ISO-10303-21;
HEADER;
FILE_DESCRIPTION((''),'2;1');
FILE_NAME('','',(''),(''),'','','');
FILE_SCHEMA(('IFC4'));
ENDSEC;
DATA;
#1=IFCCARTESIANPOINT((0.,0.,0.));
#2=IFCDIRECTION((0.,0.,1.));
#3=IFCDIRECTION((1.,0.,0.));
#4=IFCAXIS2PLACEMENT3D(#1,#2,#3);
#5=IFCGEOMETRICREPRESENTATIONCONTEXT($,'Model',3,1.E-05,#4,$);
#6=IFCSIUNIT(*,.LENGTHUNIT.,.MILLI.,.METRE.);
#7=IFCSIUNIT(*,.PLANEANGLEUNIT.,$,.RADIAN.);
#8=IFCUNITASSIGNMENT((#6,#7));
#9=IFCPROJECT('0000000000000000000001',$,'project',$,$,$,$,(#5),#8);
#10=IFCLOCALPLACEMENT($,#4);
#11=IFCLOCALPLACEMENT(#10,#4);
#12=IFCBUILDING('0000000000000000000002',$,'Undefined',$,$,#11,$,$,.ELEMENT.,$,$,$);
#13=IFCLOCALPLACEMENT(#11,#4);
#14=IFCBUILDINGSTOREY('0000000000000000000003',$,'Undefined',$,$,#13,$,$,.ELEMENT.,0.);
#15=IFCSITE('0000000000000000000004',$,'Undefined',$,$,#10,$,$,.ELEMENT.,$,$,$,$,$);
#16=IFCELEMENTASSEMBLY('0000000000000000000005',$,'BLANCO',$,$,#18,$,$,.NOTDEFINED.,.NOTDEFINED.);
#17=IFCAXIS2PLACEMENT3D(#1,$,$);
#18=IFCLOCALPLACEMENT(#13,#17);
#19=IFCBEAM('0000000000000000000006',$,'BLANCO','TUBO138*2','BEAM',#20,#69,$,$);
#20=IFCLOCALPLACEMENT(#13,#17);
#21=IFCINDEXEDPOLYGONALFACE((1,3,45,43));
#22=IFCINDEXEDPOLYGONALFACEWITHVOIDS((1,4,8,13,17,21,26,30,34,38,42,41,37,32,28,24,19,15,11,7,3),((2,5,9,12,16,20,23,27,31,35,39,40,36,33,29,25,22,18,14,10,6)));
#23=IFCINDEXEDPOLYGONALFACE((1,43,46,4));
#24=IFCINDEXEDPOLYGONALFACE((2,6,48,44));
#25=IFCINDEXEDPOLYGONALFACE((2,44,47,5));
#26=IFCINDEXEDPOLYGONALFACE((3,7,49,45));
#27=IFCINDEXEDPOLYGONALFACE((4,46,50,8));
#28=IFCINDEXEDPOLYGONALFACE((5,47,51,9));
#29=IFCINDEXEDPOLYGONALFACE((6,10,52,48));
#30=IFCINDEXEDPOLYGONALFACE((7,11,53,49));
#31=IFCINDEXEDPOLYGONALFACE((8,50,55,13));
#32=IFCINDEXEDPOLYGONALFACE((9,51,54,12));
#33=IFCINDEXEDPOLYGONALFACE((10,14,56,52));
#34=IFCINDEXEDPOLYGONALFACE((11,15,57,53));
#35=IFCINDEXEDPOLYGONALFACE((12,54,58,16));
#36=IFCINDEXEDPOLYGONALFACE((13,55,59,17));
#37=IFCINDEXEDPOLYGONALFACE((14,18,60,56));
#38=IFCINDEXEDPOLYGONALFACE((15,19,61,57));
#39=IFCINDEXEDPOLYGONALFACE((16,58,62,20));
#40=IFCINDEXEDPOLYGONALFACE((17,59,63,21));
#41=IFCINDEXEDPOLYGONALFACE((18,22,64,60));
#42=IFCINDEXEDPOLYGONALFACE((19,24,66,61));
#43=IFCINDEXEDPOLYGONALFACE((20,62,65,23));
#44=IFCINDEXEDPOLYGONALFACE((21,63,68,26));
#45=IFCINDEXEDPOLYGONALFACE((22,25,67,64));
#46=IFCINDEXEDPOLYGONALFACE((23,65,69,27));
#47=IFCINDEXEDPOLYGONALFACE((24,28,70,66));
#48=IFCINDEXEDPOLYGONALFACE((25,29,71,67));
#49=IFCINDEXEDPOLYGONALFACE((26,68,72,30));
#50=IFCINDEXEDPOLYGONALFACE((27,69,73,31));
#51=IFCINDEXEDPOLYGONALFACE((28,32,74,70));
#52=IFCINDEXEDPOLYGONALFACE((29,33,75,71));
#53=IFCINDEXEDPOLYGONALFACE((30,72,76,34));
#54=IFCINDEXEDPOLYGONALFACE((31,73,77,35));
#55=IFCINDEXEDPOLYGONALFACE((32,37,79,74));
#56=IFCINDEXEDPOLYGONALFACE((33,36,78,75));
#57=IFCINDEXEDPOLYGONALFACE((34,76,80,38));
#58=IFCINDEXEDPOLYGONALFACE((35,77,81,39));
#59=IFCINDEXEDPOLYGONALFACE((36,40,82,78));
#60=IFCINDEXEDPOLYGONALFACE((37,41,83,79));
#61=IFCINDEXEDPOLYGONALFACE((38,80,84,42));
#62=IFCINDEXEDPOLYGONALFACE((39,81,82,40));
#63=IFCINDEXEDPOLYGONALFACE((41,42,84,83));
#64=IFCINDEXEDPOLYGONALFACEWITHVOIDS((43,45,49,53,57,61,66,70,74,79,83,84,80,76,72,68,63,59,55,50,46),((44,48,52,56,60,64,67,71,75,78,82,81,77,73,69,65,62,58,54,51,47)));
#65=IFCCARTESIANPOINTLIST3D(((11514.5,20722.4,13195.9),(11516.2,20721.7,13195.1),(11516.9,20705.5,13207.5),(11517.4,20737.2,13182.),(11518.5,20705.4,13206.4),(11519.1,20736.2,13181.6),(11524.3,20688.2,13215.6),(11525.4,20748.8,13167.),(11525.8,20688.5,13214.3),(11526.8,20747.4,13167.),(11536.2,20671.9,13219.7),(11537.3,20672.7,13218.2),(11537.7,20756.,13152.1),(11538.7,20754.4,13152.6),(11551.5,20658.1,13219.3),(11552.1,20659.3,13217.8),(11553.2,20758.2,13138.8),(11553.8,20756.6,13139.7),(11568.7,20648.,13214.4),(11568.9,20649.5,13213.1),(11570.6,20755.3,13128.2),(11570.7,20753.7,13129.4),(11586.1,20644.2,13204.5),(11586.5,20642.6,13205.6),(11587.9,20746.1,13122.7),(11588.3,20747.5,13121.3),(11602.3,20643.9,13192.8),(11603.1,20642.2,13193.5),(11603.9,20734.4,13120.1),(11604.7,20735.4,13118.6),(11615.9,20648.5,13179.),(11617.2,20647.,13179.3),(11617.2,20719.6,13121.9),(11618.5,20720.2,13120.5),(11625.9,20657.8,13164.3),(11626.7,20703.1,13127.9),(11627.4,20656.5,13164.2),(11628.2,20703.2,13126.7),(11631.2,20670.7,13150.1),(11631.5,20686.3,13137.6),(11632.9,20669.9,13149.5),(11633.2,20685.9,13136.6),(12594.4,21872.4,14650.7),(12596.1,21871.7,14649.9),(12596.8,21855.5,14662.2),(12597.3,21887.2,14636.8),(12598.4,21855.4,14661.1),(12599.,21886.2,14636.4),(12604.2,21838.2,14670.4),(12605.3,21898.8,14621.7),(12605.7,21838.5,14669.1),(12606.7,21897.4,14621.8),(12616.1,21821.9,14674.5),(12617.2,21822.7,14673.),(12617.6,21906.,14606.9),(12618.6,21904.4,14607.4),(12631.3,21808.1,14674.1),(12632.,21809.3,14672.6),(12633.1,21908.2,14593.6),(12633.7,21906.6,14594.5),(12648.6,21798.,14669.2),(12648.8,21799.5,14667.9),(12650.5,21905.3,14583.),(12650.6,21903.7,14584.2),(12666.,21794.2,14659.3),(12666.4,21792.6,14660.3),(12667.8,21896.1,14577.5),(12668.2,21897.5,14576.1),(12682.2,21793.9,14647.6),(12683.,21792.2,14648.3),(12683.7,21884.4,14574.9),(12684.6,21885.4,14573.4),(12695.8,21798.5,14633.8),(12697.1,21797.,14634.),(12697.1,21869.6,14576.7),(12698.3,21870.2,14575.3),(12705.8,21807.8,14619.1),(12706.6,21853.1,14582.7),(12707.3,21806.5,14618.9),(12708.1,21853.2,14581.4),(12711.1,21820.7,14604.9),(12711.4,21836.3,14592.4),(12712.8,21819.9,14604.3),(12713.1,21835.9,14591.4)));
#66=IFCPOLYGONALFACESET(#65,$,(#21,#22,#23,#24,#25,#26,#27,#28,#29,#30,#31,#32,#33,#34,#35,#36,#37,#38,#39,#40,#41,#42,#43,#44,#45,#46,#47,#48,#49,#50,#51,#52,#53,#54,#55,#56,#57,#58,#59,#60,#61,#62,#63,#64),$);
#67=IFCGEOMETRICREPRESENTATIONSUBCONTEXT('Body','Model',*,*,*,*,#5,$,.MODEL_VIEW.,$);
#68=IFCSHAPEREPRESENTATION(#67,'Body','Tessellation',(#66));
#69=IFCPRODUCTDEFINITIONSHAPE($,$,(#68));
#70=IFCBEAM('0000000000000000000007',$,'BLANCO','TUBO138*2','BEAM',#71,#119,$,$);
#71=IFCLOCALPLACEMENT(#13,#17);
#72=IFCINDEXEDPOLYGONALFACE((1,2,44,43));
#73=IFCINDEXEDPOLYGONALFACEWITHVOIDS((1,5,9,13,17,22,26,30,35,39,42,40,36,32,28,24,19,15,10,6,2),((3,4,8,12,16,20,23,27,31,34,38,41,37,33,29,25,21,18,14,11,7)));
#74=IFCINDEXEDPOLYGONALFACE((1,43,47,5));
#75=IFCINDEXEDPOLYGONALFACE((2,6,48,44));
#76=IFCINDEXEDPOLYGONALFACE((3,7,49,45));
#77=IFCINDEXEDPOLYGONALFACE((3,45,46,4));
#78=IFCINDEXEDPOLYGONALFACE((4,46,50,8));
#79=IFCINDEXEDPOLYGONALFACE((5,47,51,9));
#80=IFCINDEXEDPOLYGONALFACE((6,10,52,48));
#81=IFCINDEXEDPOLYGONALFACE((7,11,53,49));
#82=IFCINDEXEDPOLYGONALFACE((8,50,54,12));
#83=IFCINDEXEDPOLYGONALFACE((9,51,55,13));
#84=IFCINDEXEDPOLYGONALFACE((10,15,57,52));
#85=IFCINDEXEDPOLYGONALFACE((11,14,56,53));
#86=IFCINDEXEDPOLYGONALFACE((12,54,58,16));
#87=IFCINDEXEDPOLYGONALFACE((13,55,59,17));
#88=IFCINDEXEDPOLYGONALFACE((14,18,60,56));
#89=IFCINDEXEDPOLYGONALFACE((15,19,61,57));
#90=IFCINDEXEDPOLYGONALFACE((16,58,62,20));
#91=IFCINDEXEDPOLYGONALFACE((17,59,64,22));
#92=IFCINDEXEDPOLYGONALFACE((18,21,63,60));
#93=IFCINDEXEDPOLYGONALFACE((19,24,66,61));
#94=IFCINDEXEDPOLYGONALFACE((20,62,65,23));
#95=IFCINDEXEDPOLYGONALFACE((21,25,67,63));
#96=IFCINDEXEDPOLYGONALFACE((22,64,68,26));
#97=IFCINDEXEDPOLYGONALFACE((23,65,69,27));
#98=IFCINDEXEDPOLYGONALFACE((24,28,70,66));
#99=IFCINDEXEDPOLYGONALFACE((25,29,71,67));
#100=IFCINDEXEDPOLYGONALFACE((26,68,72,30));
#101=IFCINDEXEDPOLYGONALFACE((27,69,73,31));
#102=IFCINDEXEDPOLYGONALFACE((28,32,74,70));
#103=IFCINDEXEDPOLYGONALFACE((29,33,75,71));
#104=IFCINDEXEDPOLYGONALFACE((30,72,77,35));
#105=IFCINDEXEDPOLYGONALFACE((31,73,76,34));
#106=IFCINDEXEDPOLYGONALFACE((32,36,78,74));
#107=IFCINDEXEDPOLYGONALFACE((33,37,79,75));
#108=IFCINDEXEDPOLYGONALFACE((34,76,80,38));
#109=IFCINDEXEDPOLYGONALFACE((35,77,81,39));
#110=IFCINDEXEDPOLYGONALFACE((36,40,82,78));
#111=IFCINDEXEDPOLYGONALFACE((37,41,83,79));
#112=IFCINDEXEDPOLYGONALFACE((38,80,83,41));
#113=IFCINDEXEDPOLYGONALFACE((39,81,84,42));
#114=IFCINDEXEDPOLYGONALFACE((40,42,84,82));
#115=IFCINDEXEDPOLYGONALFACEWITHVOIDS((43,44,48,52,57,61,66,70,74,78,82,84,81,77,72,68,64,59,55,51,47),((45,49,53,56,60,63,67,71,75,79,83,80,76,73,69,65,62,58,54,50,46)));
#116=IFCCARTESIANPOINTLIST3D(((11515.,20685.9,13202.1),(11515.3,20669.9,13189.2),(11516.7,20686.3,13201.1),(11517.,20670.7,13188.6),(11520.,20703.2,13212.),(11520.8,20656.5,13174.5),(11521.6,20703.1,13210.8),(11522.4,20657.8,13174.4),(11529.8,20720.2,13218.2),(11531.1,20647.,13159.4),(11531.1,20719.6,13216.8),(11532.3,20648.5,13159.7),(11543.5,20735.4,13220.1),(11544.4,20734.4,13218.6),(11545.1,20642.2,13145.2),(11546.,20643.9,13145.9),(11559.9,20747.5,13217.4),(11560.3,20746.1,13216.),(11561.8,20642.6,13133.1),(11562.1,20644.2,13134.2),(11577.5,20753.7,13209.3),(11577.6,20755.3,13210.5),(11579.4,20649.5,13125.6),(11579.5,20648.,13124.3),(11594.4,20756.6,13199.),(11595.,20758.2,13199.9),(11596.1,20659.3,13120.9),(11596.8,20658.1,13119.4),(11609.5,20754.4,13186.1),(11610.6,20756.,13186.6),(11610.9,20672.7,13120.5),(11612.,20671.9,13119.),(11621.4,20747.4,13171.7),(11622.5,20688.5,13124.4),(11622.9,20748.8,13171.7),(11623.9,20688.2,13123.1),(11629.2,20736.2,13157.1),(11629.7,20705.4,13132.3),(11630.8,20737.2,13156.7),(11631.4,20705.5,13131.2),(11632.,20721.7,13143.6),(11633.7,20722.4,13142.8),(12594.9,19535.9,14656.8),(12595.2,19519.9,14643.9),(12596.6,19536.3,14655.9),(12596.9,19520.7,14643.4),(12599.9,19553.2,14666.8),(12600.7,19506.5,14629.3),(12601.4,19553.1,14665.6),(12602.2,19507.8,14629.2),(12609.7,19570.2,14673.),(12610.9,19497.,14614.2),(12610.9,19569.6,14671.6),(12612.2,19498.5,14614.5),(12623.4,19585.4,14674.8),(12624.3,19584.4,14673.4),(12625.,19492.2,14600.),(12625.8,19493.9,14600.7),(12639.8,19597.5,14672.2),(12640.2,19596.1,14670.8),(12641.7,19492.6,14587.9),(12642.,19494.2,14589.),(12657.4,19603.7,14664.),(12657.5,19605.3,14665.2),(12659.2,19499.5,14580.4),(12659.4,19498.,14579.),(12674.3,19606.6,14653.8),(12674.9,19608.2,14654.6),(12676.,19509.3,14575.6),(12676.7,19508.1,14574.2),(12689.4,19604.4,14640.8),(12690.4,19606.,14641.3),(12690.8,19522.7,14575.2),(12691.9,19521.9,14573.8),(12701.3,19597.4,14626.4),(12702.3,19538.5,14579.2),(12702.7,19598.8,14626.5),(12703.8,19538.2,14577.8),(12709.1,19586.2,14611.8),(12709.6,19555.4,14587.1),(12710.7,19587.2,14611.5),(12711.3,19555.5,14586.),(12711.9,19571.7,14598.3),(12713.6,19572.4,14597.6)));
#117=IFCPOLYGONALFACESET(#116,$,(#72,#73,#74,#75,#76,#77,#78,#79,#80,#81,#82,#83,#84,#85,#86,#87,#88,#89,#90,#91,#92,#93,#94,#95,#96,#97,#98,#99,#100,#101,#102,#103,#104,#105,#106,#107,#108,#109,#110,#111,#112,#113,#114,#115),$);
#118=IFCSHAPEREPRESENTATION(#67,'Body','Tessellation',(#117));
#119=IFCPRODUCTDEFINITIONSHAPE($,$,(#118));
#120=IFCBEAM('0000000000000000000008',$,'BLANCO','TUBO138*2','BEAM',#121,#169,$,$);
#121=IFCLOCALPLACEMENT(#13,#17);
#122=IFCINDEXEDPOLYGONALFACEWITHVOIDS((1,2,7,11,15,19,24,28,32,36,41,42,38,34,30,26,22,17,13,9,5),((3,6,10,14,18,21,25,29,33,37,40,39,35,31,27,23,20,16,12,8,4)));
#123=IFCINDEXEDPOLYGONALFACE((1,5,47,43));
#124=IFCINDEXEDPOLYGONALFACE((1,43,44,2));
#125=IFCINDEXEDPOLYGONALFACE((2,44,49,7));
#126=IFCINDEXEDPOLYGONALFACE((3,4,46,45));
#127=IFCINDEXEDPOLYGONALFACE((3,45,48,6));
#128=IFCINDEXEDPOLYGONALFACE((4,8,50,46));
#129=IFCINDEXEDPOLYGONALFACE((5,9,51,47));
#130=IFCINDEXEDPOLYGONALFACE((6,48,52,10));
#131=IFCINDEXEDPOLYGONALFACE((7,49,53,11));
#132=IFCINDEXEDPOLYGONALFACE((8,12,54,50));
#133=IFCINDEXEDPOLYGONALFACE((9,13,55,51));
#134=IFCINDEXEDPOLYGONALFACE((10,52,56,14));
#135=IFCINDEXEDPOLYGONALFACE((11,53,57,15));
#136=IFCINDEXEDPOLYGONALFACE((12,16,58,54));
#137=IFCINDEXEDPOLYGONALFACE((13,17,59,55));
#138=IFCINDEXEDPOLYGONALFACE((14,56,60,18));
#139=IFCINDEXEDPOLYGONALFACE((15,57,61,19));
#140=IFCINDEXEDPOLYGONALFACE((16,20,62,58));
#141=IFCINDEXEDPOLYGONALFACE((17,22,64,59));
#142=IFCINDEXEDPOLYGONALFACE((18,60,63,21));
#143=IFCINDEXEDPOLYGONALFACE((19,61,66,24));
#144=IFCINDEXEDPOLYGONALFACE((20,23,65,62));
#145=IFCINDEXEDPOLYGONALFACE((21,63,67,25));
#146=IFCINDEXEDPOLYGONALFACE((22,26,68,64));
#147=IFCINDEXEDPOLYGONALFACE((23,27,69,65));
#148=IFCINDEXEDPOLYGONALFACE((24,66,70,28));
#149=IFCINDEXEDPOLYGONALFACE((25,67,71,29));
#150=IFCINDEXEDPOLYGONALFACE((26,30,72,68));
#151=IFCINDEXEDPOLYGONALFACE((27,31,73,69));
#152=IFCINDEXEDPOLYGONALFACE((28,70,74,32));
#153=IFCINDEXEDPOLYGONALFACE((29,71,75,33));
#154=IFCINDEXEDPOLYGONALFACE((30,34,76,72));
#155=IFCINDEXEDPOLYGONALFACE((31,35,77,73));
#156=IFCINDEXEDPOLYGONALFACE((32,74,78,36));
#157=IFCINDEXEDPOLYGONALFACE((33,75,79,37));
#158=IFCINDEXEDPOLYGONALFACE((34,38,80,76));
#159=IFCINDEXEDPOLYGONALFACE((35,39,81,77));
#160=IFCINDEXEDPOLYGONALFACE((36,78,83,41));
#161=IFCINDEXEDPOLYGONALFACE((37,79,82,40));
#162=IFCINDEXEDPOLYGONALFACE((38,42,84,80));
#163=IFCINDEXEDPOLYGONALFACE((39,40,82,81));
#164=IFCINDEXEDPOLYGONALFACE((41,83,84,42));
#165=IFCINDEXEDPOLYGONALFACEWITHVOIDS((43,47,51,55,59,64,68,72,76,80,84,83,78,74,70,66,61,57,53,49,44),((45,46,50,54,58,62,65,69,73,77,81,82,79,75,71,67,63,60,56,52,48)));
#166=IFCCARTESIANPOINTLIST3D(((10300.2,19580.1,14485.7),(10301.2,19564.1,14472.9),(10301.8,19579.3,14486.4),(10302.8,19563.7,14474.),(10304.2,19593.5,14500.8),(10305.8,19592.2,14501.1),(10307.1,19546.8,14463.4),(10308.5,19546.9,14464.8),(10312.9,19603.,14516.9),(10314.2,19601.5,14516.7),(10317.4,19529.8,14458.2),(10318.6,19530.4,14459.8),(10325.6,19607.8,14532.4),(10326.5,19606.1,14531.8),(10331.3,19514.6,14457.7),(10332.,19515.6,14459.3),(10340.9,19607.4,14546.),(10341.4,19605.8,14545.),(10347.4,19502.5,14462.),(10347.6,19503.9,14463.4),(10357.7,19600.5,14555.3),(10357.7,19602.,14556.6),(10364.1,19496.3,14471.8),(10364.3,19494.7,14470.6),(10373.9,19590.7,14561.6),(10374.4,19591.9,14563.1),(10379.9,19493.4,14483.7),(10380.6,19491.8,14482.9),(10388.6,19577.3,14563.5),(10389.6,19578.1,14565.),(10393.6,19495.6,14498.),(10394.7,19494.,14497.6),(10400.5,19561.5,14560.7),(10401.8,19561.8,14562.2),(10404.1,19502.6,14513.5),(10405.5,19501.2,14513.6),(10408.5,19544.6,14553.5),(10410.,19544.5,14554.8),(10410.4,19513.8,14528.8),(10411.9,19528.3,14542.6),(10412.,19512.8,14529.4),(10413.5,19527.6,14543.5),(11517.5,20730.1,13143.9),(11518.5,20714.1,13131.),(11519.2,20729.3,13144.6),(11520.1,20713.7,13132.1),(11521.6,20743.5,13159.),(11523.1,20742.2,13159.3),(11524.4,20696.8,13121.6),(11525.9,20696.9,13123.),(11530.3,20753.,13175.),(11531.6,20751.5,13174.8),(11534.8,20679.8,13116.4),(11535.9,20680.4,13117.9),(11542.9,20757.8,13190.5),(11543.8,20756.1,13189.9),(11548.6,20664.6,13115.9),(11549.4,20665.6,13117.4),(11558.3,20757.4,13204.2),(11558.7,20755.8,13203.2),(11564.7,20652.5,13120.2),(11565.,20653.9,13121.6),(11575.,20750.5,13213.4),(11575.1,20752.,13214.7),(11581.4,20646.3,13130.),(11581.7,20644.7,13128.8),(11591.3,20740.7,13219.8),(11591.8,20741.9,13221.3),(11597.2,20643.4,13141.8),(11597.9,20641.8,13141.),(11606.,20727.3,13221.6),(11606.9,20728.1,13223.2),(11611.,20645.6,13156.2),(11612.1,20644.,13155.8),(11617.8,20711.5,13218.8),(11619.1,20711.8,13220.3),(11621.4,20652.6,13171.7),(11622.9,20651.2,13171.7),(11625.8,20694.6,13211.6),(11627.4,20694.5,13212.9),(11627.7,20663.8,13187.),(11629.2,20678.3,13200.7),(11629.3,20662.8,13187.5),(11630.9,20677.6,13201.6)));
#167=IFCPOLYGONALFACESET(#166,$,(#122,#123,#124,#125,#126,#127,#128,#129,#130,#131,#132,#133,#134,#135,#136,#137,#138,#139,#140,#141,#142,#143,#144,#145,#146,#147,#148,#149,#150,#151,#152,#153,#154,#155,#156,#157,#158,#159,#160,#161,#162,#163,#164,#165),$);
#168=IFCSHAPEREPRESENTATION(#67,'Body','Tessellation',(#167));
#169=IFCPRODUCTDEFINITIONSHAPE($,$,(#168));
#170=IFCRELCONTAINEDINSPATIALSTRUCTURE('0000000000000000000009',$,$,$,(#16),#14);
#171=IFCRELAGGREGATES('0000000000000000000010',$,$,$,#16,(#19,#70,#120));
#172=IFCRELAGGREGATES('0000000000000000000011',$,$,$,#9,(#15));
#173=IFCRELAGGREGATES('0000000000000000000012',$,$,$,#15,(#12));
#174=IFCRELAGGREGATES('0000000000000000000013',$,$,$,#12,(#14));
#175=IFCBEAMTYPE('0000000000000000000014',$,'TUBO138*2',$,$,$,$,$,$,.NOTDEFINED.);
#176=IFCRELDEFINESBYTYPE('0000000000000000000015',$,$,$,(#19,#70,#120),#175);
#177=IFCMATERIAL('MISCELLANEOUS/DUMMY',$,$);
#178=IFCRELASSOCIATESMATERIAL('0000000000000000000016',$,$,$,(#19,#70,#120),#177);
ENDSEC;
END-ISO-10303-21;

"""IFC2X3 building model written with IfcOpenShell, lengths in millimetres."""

from ifc_helpers import new_model, si_unit, frame, origin_with_axes, origin_2d_with_axis, place, context, subcontext, project, spatial, hollow_circle, extrude, material, type_object, element, aggregate, save


model = new_model("IFC2X3")

# Units and contexts
model_context = context("Model", 3, precision=1e-05, world=origin_with_axes())
body_context = subcontext(model_context, "Body", "Model", "MODEL_VIEW")
ifc_project = project(units=[si_unit("LENGTHUNIT", "METRE", prefix="MILLI"), si_unit("PLANEANGLEUNIT", "RADIAN")], contexts=[model_context])

# Site, building, storey
site_placement = place(None, origin_with_axes())
site = spatial("IfcSite", under=ifc_project, at=site_placement, Name="Undefined", CompositionType="ELEMENT")
building_placement = place(site_placement, origin_with_axes())
building = spatial("IfcBuilding", under=site, at=building_placement, Name="Undefined", CompositionType="ELEMENT")
storey_placement = place(building_placement, origin_with_axes())
storey = spatial("IfcBuildingStorey", under=building, at=storey_placement, Name="Undefined", CompositionType="ELEMENT", Elevation=0.0)

# Element assembly, beams
assembly_placement = place(storey_placement, origin_with_axes())
assembly = element("IfcElementAssembly", 1, at=assembly_placement, inside=storey, Name="BLANCO", AssemblyPlace="NOTDEFINED", PredefinedType="NOTDEFINED")
ifc_material = material(Name="MISCELLANEOUS/DUMMY")
beam_type = type_object("IfcBeamType", Name="TUBO138*2", PredefinedType="NOTDEFINED")
beam_1_placement = place(assembly_placement, frame((11574.1, 20700.0, 13169.4), z_axis=(0.497966, 0.461316, -0.734314), x_axis=(0.503224, 0.535899, 0.677922)))
beam_1 = element("IfcBeam", 2, at=beam_1_placement, type_object=beam_type, material=ifc_material, Name="BLANCO", Description="TUBO138*2", ObjectType="BEAM", context=body_context, shape_type="SweptSolid", body=[
    extrude(hollow_circle(Radius=69.0, WallThickness=2.0, at=origin_2d_with_axis()), frame((2145.9, 0.0, 0.0), z_axis=(-1.0, 0.0, 0.0), x_axis=(0.0, -1.0, 0.0)), (0.0, 0.0, 1.0), 2145.9),
])
beam_2_placement = place(assembly_placement, frame((11574.1, 20700.0, 13169.4), z_axis=(0.497966, -0.461316, -0.734314), x_axis=(0.503224, -0.535899, 0.677922)))
beam_2 = element("IfcBeam", 3, at=beam_2_placement, type_object=beam_type, material=ifc_material, Name="BLANCO", Description="TUBO138*2", ObjectType="BEAM", context=body_context, shape_type="SweptSolid", body=[
    extrude(hollow_circle(Radius=69.0, WallThickness=2.0, at=origin_2d_with_axis()), frame((2145.9, 0.0, 0.0), z_axis=(-1.0, 0.0, 0.0), x_axis=(0.0, -1.0, 0.0)), (0.0, 0.0, 1.0), 2145.9),
])
beam_3_placement = place(assembly_placement, frame((11574.1, 20700.0, 13169.4), z_axis=(-0.423552, -0.461316, -0.77961), x_axis=(-0.567282, -0.535899, 0.625303)))
beam_3 = element("IfcBeam", 4, at=beam_3_placement, type_object=beam_type, material=ifc_material, Name="BLANCO", Description="TUBO138*2", ObjectType="BEAM", context=body_context, shape_type="SweptSolid", body=[
    extrude(hollow_circle(Radius=69.0, WallThickness=2.0, at=origin_2d_with_axis()), frame((2145.9, 0.0, 0.0), z_axis=(-1.0, 0.0, 0.0), x_axis=(0.0, -1.0, 0.0)), (0.0, 0.0, 1.0), 2145.9),
])
aggregate(assembly, [beam_1, beam_2, beam_3])

save(model, "model.ifc")
